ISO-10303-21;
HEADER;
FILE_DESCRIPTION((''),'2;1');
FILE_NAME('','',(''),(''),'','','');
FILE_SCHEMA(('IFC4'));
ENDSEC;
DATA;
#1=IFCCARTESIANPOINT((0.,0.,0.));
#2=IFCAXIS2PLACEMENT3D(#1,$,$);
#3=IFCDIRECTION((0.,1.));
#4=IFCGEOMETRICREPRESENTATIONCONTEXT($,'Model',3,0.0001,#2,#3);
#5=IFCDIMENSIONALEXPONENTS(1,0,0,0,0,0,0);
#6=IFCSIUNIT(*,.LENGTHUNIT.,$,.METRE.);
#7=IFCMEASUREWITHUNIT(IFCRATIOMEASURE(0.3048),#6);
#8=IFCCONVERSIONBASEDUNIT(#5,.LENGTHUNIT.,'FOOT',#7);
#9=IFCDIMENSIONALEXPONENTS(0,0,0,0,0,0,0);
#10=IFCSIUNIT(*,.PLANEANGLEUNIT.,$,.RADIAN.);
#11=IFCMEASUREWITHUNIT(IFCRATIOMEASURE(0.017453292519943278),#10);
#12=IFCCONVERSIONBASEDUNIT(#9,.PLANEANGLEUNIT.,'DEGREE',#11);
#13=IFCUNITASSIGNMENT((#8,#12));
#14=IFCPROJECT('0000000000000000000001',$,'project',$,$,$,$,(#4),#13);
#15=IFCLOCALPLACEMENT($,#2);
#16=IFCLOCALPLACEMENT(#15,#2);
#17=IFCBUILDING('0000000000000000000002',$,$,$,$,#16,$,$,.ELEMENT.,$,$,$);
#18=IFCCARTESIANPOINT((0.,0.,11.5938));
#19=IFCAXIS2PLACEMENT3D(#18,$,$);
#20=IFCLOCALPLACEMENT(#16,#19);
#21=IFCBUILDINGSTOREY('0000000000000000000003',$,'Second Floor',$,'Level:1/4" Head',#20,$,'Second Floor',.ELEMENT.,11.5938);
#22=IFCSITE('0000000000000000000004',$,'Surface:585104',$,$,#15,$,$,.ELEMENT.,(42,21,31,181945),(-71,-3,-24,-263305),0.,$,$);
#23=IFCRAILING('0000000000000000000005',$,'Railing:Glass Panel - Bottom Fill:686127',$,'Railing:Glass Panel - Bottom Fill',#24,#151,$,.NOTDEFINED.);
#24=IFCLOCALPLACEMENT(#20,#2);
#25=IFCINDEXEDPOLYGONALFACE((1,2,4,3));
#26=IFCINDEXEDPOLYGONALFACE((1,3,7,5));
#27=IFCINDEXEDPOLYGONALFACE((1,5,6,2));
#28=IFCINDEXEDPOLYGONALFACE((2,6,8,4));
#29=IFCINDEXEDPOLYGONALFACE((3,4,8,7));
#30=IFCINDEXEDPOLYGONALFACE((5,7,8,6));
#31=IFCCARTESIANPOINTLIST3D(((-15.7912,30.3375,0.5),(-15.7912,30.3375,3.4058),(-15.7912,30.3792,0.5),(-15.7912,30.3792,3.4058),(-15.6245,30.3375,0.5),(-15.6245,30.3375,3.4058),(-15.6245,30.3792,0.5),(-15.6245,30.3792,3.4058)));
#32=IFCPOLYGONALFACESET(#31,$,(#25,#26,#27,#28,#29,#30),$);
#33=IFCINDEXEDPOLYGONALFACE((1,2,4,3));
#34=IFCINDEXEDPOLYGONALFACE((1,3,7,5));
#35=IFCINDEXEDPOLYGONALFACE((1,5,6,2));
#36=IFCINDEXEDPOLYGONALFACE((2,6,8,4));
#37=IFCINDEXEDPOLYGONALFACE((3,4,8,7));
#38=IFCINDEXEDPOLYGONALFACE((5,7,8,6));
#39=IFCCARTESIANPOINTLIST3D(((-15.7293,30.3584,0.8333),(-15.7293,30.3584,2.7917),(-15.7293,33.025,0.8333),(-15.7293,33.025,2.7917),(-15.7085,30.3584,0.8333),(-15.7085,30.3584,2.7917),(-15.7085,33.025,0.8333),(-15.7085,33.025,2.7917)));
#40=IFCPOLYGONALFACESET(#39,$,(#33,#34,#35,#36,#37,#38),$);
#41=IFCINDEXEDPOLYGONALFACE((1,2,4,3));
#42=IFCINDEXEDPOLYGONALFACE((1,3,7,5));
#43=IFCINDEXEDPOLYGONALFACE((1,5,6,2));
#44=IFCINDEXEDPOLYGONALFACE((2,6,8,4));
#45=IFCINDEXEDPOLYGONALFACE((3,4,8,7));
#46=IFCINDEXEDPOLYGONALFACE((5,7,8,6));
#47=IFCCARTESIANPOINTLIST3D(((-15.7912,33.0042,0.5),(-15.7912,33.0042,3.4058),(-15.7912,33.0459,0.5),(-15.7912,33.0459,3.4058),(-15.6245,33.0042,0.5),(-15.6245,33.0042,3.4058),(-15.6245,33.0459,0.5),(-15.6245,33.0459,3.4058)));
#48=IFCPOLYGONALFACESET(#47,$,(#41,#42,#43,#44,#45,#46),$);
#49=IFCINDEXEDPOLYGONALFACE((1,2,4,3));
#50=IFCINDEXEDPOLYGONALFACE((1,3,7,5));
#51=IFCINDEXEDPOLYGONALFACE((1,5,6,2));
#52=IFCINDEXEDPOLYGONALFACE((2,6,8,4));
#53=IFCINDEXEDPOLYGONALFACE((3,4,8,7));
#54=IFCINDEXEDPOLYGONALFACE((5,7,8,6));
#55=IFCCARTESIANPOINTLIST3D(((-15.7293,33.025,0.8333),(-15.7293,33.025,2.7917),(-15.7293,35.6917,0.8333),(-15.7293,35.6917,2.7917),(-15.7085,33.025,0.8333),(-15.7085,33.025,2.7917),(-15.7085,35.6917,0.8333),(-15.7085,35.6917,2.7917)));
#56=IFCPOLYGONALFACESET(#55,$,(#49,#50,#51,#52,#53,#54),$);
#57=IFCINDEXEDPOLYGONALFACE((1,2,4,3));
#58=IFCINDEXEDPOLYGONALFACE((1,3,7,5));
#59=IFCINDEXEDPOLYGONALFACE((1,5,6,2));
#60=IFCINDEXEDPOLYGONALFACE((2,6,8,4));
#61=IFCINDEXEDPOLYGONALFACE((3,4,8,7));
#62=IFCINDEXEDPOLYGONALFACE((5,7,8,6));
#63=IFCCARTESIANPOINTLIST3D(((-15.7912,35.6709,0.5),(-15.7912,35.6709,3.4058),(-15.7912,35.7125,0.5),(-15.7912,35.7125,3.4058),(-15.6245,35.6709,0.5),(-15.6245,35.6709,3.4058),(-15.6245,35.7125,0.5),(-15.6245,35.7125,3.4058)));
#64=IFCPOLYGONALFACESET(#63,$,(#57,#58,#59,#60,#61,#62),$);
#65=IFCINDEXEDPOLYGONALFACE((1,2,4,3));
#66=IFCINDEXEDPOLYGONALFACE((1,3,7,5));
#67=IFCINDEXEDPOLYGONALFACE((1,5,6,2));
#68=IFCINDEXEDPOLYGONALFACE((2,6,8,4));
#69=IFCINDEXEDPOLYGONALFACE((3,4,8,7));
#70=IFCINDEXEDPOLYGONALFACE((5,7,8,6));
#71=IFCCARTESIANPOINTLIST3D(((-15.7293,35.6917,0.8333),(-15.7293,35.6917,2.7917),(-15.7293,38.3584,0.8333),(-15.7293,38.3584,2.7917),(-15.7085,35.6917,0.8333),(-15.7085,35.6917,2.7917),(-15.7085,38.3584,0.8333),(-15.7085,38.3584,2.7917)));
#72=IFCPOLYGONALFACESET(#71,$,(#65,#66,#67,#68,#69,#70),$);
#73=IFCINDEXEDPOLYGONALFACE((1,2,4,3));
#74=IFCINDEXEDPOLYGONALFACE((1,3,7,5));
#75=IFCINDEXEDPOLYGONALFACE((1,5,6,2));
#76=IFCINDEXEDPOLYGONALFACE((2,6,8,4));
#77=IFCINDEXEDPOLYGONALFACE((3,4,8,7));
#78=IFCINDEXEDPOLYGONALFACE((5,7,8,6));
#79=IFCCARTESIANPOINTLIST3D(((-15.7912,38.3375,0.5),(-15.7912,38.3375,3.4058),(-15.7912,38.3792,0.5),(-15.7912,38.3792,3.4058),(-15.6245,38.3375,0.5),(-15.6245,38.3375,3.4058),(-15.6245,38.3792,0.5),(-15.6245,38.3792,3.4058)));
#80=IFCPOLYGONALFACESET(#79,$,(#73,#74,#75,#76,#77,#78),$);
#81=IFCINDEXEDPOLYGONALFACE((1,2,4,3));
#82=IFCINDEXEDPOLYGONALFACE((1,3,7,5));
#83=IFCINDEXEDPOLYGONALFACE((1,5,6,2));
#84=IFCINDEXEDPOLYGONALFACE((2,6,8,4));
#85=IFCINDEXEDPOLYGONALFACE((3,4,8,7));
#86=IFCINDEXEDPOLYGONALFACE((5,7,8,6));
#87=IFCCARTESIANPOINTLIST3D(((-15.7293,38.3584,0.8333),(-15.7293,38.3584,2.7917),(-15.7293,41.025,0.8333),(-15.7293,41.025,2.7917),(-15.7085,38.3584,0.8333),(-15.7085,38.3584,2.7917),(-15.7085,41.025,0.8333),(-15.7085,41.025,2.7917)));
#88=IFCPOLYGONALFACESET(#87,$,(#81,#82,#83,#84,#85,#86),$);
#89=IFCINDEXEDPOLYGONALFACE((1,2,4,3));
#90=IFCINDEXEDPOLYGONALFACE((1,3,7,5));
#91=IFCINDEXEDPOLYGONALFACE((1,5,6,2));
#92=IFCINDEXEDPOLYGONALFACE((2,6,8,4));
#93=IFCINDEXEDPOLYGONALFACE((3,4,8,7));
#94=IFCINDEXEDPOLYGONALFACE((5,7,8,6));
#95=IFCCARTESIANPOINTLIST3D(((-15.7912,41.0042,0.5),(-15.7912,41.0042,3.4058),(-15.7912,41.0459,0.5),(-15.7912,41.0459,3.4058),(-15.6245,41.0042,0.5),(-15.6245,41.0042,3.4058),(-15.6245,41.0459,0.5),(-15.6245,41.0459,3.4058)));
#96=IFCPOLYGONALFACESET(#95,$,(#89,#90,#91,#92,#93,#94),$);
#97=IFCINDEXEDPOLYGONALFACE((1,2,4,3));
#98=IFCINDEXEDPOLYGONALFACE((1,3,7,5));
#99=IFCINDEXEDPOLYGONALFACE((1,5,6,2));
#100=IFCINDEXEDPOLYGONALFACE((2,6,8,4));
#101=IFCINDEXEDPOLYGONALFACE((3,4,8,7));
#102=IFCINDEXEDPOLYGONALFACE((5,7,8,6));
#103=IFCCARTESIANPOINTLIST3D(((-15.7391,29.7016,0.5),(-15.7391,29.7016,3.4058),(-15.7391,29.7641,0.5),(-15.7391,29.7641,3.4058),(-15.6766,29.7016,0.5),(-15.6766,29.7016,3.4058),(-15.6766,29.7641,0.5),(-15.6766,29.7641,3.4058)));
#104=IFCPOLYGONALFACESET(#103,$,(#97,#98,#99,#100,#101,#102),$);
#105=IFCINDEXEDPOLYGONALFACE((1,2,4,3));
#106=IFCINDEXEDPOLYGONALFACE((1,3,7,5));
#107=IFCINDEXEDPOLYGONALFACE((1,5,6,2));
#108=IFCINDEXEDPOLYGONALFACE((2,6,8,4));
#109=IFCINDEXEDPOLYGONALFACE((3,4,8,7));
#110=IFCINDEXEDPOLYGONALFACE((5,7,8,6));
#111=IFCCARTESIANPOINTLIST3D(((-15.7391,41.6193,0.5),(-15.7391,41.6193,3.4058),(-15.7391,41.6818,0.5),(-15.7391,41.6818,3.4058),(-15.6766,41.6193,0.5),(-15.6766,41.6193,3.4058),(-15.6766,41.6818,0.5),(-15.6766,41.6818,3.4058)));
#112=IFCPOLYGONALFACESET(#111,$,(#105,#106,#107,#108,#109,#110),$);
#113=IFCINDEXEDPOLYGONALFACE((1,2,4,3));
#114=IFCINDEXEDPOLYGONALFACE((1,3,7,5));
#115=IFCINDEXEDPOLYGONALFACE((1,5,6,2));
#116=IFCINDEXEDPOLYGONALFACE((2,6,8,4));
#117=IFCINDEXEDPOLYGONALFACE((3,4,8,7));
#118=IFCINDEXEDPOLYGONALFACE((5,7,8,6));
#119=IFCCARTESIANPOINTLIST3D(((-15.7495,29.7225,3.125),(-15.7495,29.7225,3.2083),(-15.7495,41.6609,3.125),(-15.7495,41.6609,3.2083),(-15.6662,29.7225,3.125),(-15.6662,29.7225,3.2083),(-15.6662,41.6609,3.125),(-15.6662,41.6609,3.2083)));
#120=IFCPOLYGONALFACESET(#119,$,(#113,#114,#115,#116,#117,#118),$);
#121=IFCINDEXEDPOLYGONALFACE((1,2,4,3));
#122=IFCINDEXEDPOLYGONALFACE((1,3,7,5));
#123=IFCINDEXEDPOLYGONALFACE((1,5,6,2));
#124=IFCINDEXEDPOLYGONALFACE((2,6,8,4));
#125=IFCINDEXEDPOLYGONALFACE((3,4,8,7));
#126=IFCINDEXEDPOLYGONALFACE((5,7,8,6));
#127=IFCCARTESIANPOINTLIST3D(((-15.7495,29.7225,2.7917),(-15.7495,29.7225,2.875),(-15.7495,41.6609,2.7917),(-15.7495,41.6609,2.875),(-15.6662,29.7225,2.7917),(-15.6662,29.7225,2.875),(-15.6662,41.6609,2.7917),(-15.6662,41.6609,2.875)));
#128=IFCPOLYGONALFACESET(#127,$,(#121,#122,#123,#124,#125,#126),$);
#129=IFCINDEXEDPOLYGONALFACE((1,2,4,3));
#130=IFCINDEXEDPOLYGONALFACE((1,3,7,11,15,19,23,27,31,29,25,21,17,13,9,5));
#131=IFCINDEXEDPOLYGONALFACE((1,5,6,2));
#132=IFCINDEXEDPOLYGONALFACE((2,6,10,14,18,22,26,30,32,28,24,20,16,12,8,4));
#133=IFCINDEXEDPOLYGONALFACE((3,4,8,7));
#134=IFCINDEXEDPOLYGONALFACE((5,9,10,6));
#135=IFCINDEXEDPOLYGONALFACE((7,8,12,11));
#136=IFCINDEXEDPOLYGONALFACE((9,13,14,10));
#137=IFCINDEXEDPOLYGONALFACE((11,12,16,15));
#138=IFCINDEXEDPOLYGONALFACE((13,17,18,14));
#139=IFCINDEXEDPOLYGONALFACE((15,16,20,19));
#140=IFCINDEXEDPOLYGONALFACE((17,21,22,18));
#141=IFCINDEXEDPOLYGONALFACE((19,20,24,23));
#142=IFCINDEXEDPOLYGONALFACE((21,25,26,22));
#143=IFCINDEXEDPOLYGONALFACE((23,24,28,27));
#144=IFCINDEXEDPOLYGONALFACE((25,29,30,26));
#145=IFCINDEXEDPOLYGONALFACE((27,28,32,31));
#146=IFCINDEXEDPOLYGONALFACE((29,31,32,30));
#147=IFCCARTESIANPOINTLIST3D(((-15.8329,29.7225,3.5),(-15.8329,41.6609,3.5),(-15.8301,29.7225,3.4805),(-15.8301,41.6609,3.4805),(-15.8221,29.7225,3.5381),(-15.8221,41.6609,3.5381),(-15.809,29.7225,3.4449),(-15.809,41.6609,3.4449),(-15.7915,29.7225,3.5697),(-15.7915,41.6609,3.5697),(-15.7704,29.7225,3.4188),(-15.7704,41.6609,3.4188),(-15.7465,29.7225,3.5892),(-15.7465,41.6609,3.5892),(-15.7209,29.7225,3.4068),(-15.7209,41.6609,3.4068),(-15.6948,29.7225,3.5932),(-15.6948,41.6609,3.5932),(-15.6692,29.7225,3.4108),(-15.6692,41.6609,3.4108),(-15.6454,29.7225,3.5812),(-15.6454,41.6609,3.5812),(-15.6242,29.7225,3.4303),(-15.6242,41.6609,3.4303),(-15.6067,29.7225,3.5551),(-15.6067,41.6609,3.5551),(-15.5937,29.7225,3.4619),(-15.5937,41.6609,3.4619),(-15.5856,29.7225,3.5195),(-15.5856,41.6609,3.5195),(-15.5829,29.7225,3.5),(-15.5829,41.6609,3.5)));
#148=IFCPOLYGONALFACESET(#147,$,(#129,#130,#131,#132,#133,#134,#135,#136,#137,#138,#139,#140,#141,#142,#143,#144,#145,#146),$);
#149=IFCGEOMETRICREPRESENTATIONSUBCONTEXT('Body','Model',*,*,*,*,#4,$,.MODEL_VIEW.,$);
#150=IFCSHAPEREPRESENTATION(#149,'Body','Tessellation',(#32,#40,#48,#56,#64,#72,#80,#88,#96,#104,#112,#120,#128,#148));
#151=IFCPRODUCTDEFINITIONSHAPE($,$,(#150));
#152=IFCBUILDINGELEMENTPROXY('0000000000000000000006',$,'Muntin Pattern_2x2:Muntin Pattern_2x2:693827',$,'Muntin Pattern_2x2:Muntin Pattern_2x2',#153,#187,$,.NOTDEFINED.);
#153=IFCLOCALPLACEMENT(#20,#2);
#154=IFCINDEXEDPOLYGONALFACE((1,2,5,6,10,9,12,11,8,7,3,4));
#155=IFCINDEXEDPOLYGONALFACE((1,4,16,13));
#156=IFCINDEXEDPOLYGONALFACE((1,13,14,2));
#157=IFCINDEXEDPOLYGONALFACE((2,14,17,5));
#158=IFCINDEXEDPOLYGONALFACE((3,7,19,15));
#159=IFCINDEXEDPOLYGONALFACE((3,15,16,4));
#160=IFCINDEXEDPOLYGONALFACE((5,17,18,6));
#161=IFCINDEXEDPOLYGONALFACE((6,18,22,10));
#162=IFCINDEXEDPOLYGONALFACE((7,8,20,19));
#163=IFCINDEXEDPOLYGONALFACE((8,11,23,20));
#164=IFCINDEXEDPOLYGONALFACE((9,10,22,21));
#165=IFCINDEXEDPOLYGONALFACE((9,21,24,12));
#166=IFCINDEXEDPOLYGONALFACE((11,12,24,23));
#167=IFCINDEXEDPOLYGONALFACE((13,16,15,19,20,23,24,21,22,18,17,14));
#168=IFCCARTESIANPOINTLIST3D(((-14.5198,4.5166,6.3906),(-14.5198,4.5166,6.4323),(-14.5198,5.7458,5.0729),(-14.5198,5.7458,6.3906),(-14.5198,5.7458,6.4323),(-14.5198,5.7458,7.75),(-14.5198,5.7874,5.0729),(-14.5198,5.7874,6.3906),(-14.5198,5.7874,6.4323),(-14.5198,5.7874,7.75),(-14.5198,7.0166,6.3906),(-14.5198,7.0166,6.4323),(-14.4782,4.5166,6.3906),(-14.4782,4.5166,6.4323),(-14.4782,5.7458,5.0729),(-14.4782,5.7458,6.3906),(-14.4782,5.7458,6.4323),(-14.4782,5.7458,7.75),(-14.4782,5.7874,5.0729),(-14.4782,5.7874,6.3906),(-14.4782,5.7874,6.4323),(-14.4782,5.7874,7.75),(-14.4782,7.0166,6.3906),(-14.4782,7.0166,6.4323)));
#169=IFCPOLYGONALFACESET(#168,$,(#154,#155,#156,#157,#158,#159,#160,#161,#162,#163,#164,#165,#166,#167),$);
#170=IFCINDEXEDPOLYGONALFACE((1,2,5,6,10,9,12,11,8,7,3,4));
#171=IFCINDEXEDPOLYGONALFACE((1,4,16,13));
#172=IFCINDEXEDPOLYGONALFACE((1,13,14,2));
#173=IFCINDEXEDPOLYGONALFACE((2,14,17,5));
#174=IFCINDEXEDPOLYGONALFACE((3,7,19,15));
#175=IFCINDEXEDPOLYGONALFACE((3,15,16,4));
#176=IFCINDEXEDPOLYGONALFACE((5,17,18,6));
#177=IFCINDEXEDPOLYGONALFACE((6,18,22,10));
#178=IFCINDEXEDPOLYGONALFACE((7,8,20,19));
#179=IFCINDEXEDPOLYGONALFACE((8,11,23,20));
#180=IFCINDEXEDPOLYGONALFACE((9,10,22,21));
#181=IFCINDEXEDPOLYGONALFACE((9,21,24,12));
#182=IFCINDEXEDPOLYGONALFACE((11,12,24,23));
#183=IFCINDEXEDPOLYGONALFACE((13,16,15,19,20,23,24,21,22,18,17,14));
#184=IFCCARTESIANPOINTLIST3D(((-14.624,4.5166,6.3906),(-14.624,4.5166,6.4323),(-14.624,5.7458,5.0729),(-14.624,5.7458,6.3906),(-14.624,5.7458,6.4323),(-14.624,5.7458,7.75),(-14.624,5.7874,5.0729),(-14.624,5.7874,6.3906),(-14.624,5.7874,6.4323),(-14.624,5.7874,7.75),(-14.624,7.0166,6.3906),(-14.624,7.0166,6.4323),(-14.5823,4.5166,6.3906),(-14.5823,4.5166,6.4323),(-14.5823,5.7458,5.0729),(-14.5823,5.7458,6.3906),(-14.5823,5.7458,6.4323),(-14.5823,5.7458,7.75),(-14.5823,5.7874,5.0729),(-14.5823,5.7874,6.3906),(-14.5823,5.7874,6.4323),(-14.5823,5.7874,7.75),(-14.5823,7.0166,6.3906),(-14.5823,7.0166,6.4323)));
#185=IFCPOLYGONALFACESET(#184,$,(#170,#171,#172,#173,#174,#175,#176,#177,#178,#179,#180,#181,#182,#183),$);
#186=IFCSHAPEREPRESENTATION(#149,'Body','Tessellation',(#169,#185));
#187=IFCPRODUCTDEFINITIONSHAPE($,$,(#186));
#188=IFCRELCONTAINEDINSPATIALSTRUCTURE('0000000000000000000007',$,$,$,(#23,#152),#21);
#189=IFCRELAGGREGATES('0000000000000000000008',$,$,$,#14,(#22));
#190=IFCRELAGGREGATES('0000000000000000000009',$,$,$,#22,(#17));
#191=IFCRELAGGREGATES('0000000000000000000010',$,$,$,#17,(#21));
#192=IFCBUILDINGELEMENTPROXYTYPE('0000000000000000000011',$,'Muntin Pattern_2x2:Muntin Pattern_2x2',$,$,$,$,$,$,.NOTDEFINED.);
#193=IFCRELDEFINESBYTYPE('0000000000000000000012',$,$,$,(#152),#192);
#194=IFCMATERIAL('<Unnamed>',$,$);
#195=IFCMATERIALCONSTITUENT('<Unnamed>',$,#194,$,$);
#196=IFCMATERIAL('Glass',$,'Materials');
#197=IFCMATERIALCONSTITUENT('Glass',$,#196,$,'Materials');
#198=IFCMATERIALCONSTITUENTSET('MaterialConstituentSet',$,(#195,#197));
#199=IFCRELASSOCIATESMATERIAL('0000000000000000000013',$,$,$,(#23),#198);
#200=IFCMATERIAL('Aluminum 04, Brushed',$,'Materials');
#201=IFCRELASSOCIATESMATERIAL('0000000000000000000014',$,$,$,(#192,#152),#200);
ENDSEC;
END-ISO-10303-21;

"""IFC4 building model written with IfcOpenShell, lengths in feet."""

from ifc_helpers import new_model, entity, si_unit, converted_unit, direction, frame, origin, place, context, subcontext, project, spatial, indexed_curve, outline, extrude, source, transform, mapped, material, constituent, constituent_set, type_object, type_shapes, element, save


model = new_model("IFC4")

# Units and contexts
model_context = context("Model", 3, precision=0.0001, world=origin(), true_north=direction((0.0, 1.0)))
body_context = subcontext(model_context, "Body", "Model", "MODEL_VIEW")
ifc_project = project(units=[converted_unit("LENGTHUNIT", "FOOT", entity("IfcRatioMeasure", 0.3048), si_unit("LENGTHUNIT", "METRE"), dimensions=[1, 0, 0, 0, 0, 0, 0]), converted_unit("PLANEANGLEUNIT", "DEGREE", entity("IfcRatioMeasure", 0.017453292519943278), si_unit("PLANEANGLEUNIT", "RADIAN"), dimensions=[0, 0, 0, 0, 0, 0, 0])], contexts=[model_context])

# Site, building, storey
site_placement = place(None, origin())
site = spatial("IfcSite", under=ifc_project, at=site_placement, Name="Surface:585104", CompositionType="ELEMENT", RefLatitude=(42, 21, 31, 181945), RefLongitude=(-71, -3, -24, -263305), RefElevation=0.0)
building_placement = place(site_placement, origin())
building = spatial("IfcBuilding", under=site, at=building_placement, CompositionType="ELEMENT")
storey_placement = place(building_placement, frame((0.0, 0.0, 11.5938)))
storey = spatial("IfcBuildingStorey", under=building, at=storey_placement, Name="Second Floor", ObjectType="Level:1/4\" Head", LongName="Second Floor", CompositionType="ELEMENT", Elevation=11.5938)

# Shared definitions
ifc_material_1 = material(Name="Aluminum 04, Brushed", Category="Materials")

# Shared definitions
ifc_material_2 = material(Name="<Unnamed>")

# Railing
ifc_constituent_1 = constituent(ifc_material_2, Name="<Unnamed>")
ifc_material_3 = material(Name="Glass", Category="Materials")
ifc_constituent_2 = constituent(ifc_material_3, Name="Glass", Category="Materials")
ifc_constituent_set = constituent_set(constituents=[ifc_constituent_1, ifc_constituent_2], Name="MaterialConstituentSet")
railing_1_placement = place(storey_placement, origin())
element("IfcRailing", 1, at=railing_1_placement, inside=storey, material=ifc_constituent_set, Name="Railing:Glass Panel - Bottom Fill:686127", ObjectType="Railing:Glass Panel - Bottom Fill", PredefinedType="NOTDEFINED", context=body_context, shape_type="SweptSolid", body=[
    extrude(outline(indexed_curve([(-0.0833, -0.0208), (0.0833, -0.0208), (0.0833, 0.0208), (-0.0833, 0.0208), (-0.0833, -0.0208)], self_intersect=False)), frame((-15.7079, 30.3584, 0.5), z_axis=(0.0, 0.0, 1.0), x_axis=(-1.0, 0.0, 0.0)), (0.0, 0.0, 1.0), 2.9058),
    extrude(outline(indexed_curve([(-1.3333, -0.0104), (1.3333, -0.0104), (1.3333, 0.0104), (-1.3333, 0.0104), (-1.3333, -0.0104)], self_intersect=False)), frame((-15.7189, 31.6917, 0.8333), z_axis=(0.0, 0.0, 1.0), x_axis=(0.0, -1.0, 0.0)), (0.0, 0.0, 1.0), 1.9583),
    extrude(outline(indexed_curve([(-0.0833, -0.0208), (0.0833, -0.0208), (0.0833, 0.0208), (-0.0833, 0.0208), (-0.0833, -0.0208)], self_intersect=False)), frame((-15.7079, 33.025, 0.5), z_axis=(0.0, 0.0, 1.0), x_axis=(-1.0, 0.0, 0.0)), (0.0, 0.0, 1.0), 2.9058),
    extrude(outline(indexed_curve([(-1.3333, -0.0104), (1.3333, -0.0104), (1.3333, 0.0104), (-1.3333, 0.0104), (-1.3333, -0.0104)], self_intersect=False)), frame((-15.7189, 34.3584, 0.8333), z_axis=(0.0, 0.0, 1.0), x_axis=(0.0, -1.0, 0.0)), (0.0, 0.0, 1.0), 1.9583),
    extrude(outline(indexed_curve([(-0.0833, -0.0208), (0.0833, -0.0208), (0.0833, 0.0208), (-0.0833, 0.0208), (-0.0833, -0.0208)], self_intersect=False)), frame((-15.7079, 35.6917, 0.5), z_axis=(0.0, 0.0, 1.0), x_axis=(-1.0, 0.0, 0.0)), (0.0, 0.0, 1.0), 2.9058),
    extrude(outline(indexed_curve([(-1.3333, -0.0104), (1.3333, -0.0104), (1.3333, 0.0104), (-1.3333, 0.0104), (-1.3333, -0.0104)], self_intersect=False)), frame((-15.7189, 37.025, 0.8333), z_axis=(0.0, 0.0, 1.0), x_axis=(0.0, -1.0, 0.0)), (0.0, 0.0, 1.0), 1.9583),
    extrude(outline(indexed_curve([(-0.0833, -0.0208), (0.0833, -0.0208), (0.0833, 0.0208), (-0.0833, 0.0208), (-0.0833, -0.0208)], self_intersect=False)), frame((-15.7079, 38.3584, 0.5), z_axis=(0.0, 0.0, 1.0), x_axis=(-1.0, 0.0, 0.0)), (0.0, 0.0, 1.0), 2.9058),
    extrude(outline(indexed_curve([(-1.3333, -0.0104), (1.3333, -0.0104), (1.3333, 0.0104), (-1.3333, 0.0104), (-1.3333, -0.0104)], self_intersect=False)), frame((-15.7189, 39.6917, 0.8333), z_axis=(0.0, 0.0, 1.0), x_axis=(0.0, -1.0, 0.0)), (0.0, 0.0, 1.0), 1.9583),
    extrude(outline(indexed_curve([(-0.0833, -0.0208), (0.0833, -0.0208), (0.0833, 0.0208), (-0.0833, 0.0208), (-0.0833, -0.0208)], self_intersect=False)), frame((-15.7079, 41.025, 0.5), z_axis=(0.0, 0.0, 1.0), x_axis=(-1.0, 0.0, 0.0)), (0.0, 0.0, 1.0), 2.9058),
    extrude(outline(indexed_curve([(-0.0312, -0.0312), (0.0312, -0.0312), (0.0312, 0.0312), (-0.0312, 0.0312), (-0.0312, -0.0312)], self_intersect=False)), frame((-15.7079, 29.7329, 0.5), z_axis=(0.0, 0.0, 1.0), x_axis=(-1.0, 0.0, 0.0)), (0.0, 0.0, 1.0), 2.9058),
    extrude(outline(indexed_curve([(-0.0312, -0.0312), (0.0312, -0.0312), (0.0312, 0.0312), (-0.0312, 0.0312), (-0.0312, -0.0312)], self_intersect=False)), frame((-15.7079, 41.6505, 0.5), z_axis=(0.0, 0.0, 1.0), x_axis=(-1.0, 0.0, 0.0)), (0.0, 0.0, 1.0), 2.9058),
    extrude(outline(indexed_curve([(-5.9692, -0.0417), (5.9692, -0.0417), (5.9692, 0.0417), (-5.9692, 0.0417), (-5.9692, -0.0417)], self_intersect=False)), frame((-15.7079, 35.6917, 3.125), z_axis=(0.0, 0.0, 1.0), x_axis=(0.0, -1.0, 0.0)), (0.0, 0.0, 1.0), 0.0833),
    extrude(outline(indexed_curve([(-5.9692, -0.0417), (5.9692, -0.0417), (5.9692, 0.0417), (-5.9692, 0.0417), (-5.9692, -0.0417)], self_intersect=False)), frame((-15.7079, 35.6917, 2.7917), z_axis=(0.0, 0.0, 1.0), x_axis=(0.0, -1.0, 0.0)), (0.0, 0.0, 1.0), 0.0833),
    extrude(outline(indexed_curve([(-0.0341, -0.1203), (0.0055, -0.1203), (0.0442, -0.0995), (0.0753, -0.0615), (0.0933, -0.0129), (0.0952, 0.038), (0.0806, 0.0823), (0.0521, 0.1123), (0.0341, 0.1203), (-0.0055, 0.1203), (-0.0442, 0.0995), (-0.0753, 0.0615), (-0.0933, 0.0129), (-0.0952, -0.038), (-0.0806, -0.0823), (-0.0521, -0.1123), (-0.0341, -0.1203)], self_intersect=False)), frame((-15.7079, 29.7225, 3.5), z_axis=(0.0, 1.0, 0.0), x_axis=(-0.27267, 0.0, -0.962108)), (0.0, 0.0, 1.0), 11.9385),
])

# Building element proxy
building_element_proxy_type_1 = type_object("IfcBuildingElementProxyType", Name="Muntin Pattern_2x2:Muntin Pattern_2x2", PredefinedType="NOTDEFINED", material=ifc_material_1)
shared_shape_1 = source(origin(), body_context, "Body", "SweptSolid", [
    extrude(outline(indexed_curve([(0.0208, -0.0208), (1.3385, -0.0208), (1.3385, 0.0208), (0.0208, 0.0208), (0.0208, 1.25), (-0.0208, 1.25), (-0.0208, 0.0208), (-1.3385, 0.0208), (-1.3385, -0.0208), (-0.0208, -0.0208), (-0.0208, -1.25), (0.0208, -1.25), (0.0208, -0.0208)], self_intersect=False)), frame((0.0, -0.0729, 1.3385), z_axis=(0.0, 1.0, 0.0), x_axis=(0.0, 0.0, 1.0)), (0.0, 0.0, 1.0), 0.0417),
    extrude(outline(indexed_curve([(0.0208, -0.0208), (1.3385, -0.0208), (1.3385, 0.0208), (0.0208, 0.0208), (0.0208, 1.25), (-0.0208, 1.25), (-0.0208, 0.0208), (-1.3385, 0.0208), (-1.3385, -0.0208), (-0.0208, -0.0208), (-0.0208, -1.25), (0.0208, -1.25), (0.0208, -0.0208)], self_intersect=False)), frame((0.0, 0.0313, 1.3385), z_axis=(0.0, 1.0, 0.0), x_axis=(0.0, 0.0, 1.0)), (0.0, 0.0, 1.0), 0.0417),
])
type_shapes(building_element_proxy_type_1, [shared_shape_1])
for number, where, z_axis, x_axis, name in (
    (2, (-14.5511, 5.7666, 5.0729), (0.0, 0.0, 1.0), (0.0, 1.0, 0.0), "Muntin Pattern_2x2:Muntin Pattern_2x2:693827"),
):
    element("IfcBuildingElementProxy", number, at=place(storey_placement, frame(where, z_axis=z_axis, x_axis=x_axis)), inside=storey, type_object=building_element_proxy_type_1, material=ifc_material_1, Name=name, ObjectType="Muntin Pattern_2x2:Muntin Pattern_2x2", PredefinedType="NOTDEFINED", context=body_context, shape_type="MappedRepresentation", body=[
        mapped(shared_shape_1, transform((0.0, 0.0, 0.0), scale=1.0)),
    ])

save(model, "model.ifc")
